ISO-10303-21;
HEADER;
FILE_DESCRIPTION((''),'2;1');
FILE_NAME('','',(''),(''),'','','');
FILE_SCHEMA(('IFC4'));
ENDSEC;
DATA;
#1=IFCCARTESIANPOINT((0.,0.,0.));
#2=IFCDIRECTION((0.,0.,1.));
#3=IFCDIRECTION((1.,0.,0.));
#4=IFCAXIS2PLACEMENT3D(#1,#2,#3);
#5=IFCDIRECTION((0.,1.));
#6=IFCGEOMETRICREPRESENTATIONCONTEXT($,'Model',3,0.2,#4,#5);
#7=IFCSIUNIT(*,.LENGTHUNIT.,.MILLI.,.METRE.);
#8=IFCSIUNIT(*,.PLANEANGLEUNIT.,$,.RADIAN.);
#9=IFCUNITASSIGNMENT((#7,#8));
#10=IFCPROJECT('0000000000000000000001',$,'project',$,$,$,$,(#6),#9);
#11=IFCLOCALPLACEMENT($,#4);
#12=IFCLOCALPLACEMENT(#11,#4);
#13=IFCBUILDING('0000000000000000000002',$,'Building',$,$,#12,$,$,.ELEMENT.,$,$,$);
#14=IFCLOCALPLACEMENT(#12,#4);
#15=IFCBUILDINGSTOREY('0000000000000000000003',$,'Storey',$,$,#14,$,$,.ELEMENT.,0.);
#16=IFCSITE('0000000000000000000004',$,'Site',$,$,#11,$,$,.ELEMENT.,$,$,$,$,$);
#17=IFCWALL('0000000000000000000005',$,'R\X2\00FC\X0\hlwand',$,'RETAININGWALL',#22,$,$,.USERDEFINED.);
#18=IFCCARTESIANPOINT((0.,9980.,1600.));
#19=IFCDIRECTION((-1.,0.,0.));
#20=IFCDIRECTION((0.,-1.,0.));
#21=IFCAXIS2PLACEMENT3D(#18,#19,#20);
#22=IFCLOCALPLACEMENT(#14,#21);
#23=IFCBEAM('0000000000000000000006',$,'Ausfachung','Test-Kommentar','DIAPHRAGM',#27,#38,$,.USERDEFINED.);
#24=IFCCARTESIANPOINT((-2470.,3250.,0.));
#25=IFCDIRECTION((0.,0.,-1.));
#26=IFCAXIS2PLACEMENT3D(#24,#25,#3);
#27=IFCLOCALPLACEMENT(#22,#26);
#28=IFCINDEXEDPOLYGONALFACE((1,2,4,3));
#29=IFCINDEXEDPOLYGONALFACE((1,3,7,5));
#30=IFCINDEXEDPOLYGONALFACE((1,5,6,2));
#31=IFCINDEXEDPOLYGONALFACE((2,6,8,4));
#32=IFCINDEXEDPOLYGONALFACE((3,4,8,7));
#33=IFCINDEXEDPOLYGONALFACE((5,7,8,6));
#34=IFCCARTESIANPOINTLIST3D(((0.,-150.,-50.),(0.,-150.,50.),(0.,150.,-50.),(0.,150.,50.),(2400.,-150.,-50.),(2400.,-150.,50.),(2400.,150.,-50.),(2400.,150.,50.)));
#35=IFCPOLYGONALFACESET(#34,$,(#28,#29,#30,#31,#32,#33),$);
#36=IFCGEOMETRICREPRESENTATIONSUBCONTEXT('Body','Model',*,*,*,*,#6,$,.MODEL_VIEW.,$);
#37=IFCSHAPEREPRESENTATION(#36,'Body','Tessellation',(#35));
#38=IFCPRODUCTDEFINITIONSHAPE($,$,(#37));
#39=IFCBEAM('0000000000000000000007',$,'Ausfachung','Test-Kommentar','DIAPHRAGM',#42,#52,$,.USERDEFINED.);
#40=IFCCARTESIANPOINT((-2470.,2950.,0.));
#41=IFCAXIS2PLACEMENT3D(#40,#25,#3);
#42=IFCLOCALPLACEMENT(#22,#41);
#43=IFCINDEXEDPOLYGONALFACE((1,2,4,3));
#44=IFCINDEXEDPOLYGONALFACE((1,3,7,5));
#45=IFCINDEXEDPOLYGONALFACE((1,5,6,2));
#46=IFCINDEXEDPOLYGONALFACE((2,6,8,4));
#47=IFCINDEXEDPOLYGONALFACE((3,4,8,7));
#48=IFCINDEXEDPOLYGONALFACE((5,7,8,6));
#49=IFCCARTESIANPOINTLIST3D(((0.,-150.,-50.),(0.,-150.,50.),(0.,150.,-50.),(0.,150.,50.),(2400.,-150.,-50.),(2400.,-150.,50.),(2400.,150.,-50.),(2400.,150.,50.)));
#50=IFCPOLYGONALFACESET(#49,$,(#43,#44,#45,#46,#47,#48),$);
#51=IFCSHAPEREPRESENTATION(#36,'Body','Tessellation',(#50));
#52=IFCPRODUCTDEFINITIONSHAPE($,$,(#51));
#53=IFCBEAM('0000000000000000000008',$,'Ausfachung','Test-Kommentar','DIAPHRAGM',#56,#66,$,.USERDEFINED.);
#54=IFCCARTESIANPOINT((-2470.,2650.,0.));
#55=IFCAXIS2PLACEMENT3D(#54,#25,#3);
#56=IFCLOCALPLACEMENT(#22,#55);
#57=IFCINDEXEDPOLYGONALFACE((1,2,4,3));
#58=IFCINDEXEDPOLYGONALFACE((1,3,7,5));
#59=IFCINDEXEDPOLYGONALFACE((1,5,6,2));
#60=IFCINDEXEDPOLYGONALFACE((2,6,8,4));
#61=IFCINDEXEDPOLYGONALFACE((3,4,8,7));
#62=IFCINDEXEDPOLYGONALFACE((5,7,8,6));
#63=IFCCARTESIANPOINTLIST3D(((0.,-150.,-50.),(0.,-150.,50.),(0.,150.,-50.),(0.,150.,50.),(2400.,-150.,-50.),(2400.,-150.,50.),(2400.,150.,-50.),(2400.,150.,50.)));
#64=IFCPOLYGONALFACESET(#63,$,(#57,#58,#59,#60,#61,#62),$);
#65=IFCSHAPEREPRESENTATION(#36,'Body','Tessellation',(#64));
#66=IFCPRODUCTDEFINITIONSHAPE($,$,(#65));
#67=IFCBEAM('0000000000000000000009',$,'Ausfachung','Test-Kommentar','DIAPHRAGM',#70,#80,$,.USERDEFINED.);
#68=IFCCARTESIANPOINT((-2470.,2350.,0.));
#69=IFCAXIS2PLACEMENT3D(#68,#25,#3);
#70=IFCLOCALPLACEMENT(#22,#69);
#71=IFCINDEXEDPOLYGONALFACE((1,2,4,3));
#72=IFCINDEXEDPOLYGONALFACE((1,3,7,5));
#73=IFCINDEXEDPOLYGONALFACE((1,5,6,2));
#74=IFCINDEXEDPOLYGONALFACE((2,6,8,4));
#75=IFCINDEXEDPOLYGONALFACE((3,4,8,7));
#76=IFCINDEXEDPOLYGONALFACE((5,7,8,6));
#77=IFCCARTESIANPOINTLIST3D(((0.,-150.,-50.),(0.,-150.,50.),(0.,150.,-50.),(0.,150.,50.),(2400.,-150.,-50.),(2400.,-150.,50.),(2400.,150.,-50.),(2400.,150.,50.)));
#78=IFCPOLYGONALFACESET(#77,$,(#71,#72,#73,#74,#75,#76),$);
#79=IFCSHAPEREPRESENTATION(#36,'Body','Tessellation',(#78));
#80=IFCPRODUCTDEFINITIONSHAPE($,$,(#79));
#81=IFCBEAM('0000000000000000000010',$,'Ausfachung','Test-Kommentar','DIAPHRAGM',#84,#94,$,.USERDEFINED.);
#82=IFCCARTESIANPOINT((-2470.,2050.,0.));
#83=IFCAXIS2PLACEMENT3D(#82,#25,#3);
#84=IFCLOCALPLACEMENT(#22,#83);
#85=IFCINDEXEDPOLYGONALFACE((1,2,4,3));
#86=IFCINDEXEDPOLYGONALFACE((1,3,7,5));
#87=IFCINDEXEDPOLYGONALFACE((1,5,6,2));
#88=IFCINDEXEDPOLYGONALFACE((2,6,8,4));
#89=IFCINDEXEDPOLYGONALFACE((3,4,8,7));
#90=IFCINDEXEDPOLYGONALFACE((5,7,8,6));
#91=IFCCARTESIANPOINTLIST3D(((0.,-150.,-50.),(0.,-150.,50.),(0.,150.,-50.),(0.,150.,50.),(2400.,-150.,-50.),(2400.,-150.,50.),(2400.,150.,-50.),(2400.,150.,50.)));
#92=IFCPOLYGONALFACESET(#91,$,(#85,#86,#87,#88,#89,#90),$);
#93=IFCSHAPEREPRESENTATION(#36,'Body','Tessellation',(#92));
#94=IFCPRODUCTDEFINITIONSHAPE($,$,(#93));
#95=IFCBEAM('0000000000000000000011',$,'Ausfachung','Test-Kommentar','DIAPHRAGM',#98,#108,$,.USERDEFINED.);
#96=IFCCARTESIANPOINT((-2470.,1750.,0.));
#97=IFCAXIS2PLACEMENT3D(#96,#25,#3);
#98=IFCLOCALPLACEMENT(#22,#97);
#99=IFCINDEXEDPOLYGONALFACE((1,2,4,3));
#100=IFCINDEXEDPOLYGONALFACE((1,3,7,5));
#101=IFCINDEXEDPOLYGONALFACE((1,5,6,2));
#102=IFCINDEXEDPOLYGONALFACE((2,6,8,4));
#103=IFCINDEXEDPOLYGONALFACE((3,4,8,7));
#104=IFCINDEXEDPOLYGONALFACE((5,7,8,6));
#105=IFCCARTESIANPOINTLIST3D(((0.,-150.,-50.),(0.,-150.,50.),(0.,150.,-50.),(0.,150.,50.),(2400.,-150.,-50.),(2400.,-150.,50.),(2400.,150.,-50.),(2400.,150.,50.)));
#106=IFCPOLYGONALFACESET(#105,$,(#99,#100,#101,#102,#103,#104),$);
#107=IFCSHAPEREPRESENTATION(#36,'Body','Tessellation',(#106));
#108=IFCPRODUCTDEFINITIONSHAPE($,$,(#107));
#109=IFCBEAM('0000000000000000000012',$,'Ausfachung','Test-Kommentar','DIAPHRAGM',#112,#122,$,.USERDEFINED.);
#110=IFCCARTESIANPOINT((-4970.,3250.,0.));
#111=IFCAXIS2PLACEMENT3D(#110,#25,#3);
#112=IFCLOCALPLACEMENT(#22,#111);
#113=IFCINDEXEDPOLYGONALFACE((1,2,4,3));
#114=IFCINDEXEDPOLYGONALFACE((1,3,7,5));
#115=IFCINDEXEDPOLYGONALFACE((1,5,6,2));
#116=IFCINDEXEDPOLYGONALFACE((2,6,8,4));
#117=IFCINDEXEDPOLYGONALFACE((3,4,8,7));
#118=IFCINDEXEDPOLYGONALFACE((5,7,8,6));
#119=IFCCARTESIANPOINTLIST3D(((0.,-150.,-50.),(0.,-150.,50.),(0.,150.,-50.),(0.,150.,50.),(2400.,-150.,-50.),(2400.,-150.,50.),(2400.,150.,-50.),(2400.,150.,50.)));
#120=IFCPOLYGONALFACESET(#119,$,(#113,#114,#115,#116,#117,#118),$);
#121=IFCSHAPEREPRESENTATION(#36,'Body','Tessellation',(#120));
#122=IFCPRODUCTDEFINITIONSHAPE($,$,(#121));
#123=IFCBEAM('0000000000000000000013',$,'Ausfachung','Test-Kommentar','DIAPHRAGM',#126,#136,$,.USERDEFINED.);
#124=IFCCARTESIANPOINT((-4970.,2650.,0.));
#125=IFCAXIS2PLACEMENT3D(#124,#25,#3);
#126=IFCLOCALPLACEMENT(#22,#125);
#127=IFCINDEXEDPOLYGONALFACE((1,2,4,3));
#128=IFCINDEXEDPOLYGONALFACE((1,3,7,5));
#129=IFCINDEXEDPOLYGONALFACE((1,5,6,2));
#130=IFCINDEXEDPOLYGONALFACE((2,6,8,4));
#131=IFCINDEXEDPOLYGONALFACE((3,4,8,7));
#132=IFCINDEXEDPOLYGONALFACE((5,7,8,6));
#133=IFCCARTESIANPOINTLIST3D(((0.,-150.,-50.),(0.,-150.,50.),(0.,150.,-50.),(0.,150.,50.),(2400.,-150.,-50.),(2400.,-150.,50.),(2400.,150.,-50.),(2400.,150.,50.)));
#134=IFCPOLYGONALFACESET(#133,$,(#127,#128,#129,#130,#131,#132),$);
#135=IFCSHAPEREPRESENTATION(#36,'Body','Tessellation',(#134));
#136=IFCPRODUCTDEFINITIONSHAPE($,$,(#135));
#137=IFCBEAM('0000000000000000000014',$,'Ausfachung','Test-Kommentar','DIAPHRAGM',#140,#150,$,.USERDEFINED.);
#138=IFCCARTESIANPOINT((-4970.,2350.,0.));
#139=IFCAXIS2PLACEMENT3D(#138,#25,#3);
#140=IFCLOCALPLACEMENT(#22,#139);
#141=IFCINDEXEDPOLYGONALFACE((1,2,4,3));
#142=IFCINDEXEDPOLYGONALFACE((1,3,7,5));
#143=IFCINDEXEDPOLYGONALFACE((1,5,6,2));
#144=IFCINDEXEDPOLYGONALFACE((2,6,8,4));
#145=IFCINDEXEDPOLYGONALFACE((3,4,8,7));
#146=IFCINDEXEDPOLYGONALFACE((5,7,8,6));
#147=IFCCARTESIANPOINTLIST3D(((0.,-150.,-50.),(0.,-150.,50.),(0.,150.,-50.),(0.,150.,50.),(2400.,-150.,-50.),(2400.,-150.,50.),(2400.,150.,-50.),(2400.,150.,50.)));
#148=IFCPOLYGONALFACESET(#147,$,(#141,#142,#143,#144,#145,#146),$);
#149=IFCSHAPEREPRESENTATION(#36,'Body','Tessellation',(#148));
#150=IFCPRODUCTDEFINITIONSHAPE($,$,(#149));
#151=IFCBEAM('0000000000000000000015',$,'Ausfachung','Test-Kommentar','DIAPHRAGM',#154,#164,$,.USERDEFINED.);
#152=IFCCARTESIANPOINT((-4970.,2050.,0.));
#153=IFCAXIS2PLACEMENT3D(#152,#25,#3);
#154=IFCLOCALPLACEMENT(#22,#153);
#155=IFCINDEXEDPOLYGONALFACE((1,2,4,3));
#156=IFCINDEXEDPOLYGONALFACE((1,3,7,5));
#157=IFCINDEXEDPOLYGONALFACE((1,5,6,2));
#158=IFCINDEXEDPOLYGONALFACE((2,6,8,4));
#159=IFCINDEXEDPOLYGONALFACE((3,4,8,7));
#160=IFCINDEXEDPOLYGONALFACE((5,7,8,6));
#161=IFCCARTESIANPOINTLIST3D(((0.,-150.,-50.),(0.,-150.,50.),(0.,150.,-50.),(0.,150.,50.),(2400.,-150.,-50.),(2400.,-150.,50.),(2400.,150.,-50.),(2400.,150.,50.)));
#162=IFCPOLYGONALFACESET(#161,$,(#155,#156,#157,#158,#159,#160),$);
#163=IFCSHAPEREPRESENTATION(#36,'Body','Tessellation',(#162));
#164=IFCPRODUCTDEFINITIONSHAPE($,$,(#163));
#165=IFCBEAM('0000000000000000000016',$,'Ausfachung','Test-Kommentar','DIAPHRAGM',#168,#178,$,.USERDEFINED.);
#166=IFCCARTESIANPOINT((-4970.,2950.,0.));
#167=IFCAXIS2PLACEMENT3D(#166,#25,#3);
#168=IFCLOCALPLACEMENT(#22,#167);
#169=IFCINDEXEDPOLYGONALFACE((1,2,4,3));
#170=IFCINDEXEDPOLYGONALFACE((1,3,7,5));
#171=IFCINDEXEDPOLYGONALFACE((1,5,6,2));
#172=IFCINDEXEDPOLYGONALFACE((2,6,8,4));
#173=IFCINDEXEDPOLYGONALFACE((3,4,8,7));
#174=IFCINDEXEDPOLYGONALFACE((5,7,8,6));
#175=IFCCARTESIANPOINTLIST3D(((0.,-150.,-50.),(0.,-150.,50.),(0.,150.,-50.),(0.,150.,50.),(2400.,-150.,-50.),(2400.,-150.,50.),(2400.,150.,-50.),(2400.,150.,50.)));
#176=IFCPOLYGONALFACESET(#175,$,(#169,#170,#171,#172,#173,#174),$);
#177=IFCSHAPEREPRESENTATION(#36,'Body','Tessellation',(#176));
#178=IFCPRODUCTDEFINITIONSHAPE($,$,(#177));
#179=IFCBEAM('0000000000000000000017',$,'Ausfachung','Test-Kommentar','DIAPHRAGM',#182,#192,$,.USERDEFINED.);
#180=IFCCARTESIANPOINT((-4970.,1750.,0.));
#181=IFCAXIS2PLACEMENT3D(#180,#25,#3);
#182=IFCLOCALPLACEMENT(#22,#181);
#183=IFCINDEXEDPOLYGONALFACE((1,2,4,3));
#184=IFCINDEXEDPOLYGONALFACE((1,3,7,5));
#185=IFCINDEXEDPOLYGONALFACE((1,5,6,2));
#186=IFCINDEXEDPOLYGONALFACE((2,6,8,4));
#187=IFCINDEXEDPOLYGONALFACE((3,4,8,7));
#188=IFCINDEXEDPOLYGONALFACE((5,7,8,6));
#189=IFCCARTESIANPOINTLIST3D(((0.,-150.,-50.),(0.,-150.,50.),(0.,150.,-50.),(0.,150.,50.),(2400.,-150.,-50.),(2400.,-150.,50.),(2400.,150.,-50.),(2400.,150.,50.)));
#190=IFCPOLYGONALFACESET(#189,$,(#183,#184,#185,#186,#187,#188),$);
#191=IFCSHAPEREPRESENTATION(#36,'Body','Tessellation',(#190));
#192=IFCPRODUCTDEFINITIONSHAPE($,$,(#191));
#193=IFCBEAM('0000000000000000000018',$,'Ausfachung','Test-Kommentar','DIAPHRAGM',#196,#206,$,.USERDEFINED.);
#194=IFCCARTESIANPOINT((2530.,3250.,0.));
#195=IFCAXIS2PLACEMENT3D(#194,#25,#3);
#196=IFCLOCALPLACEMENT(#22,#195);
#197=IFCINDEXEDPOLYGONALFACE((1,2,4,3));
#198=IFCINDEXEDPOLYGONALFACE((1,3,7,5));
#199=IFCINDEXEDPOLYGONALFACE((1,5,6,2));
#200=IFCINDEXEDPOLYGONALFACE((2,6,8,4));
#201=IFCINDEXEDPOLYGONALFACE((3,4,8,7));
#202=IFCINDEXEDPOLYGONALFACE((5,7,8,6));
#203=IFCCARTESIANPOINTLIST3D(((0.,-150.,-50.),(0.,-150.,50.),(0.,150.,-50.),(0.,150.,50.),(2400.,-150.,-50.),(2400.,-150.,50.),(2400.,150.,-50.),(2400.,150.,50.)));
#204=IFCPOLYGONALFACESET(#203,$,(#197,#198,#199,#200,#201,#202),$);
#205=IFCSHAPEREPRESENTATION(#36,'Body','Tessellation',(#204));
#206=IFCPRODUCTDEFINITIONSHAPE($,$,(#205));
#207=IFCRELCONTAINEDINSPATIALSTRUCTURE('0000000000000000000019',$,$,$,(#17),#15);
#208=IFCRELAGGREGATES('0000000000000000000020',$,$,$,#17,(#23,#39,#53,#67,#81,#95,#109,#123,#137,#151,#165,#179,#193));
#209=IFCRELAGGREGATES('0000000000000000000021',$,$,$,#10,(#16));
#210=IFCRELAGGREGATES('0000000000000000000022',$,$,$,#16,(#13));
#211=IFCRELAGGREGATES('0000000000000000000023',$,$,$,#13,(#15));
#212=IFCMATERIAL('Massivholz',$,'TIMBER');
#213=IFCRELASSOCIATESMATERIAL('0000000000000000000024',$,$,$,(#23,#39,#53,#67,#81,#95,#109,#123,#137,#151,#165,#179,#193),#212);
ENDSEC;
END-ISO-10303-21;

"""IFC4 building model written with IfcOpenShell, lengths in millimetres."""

from ifc_helpers import new_model, si_unit, direction, frame, origin_with_axes, place, context, subcontext, project, spatial, line, indexed_curve, outline, extrude, material, element, aggregate, save


model = new_model("IFC4")

# Units and contexts
model_context = context("Model", 3, precision=0.2, world=origin_with_axes(), true_north=direction((0.0, 1.0)))
body_context = subcontext(model_context, "Body", "Model", "MODEL_VIEW")
ifc_project = project(units=[si_unit("LENGTHUNIT", "METRE", prefix="MILLI"), si_unit("PLANEANGLEUNIT", "RADIAN")], contexts=[model_context])

# Site, building, storey
site_placement = place(None, origin_with_axes())
site = spatial("IfcSite", under=ifc_project, at=site_placement, Name="Site", CompositionType="ELEMENT")
building_placement = place(site_placement, origin_with_axes())
building = spatial("IfcBuilding", under=site, at=building_placement, Name="Building", CompositionType="ELEMENT")
storey_placement = place(building_placement, origin_with_axes())
storey = spatial("IfcBuildingStorey", under=building, at=storey_placement, Name="Storey", CompositionType="ELEMENT", Elevation=0.0)

# Wall, beams
wall_placement = place(storey_placement, frame((0.0, 9980.0, 1600.0), z_axis=(-1.0, 0.0, 0.0), x_axis=(0.0, -1.0, 0.0)))
wall = element("IfcWall", 1, at=wall_placement, inside=storey, Name="Rühlwand", ObjectType="RETAININGWALL", PredefinedType="USERDEFINED")
ifc_material_1 = material(Name="Massivholz", Category="TIMBER")
beam_1_placement = place(wall_placement, frame((-2470.0, 3250.0, 0.0), z_axis=(0.0, 0.0, -1.0), x_axis=(1.0, 0.0, 0.0)))
beam_1 = element("IfcBeam", 2, at=beam_1_placement, material=ifc_material_1, Name="Ausfachung", Description="Test-Kommentar", ObjectType="DIAPHRAGM", PredefinedType="USERDEFINED", context=body_context, shape_type="SolidModel", body=[
    extrude(outline(indexed_curve([(-50.0, -150.0), (50.0, -150.0), (50.0, 150.0), (-50.0, 150.0)], segments=[line(1, 2, 3, 4, 1)])), frame((0.0, 0.0, 0.0), z_axis=(-1.0, 0.0, 0.0), x_axis=(0.0, 0.0, 1.0)), (0.0, 0.0, -1.0), 2400.0),
])
beam_2_placement = place(wall_placement, frame((-2470.0, 2950.0, 0.0), z_axis=(0.0, 0.0, -1.0), x_axis=(1.0, 0.0, 0.0)))
beam_2 = element("IfcBeam", 3, at=beam_2_placement, material=ifc_material_1, Name="Ausfachung", Description="Test-Kommentar", ObjectType="DIAPHRAGM", PredefinedType="USERDEFINED", context=body_context, shape_type="SolidModel", body=[
    extrude(outline(indexed_curve([(-50.0, -150.0), (50.0, -150.0), (50.0, 150.0), (-50.0, 150.0)], segments=[line(1, 2, 3, 4, 1)])), frame((0.0, 0.0, 0.0), z_axis=(-1.0, 0.0, 0.0), x_axis=(0.0, 0.0, 1.0)), (0.0, 0.0, -1.0), 2400.0),
])
beam_3_placement = place(wall_placement, frame((-2470.0, 2650.0, 0.0), z_axis=(0.0, 0.0, -1.0), x_axis=(1.0, 0.0, 0.0)))
beam_3 = element("IfcBeam", 4, at=beam_3_placement, material=ifc_material_1, Name="Ausfachung", Description="Test-Kommentar", ObjectType="DIAPHRAGM", PredefinedType="USERDEFINED", context=body_context, shape_type="SolidModel", body=[
    extrude(outline(indexed_curve([(-50.0, -150.0), (50.0, -150.0), (50.0, 150.0), (-50.0, 150.0)], segments=[line(1, 2, 3, 4, 1)])), frame((0.0, 0.0, 0.0), z_axis=(-1.0, 0.0, 0.0), x_axis=(0.0, 0.0, 1.0)), (0.0, 0.0, -1.0), 2400.0),
])
beam_4_placement = place(wall_placement, frame((-2470.0, 2350.0, 0.0), z_axis=(0.0, 0.0, -1.0), x_axis=(1.0, 0.0, 0.0)))
beam_4 = element("IfcBeam", 5, at=beam_4_placement, material=ifc_material_1, Name="Ausfachung", Description="Test-Kommentar", ObjectType="DIAPHRAGM", PredefinedType="USERDEFINED", context=body_context, shape_type="SolidModel", body=[
    extrude(outline(indexed_curve([(-50.0, -150.0), (50.0, -150.0), (50.0, 150.0), (-50.0, 150.0)], segments=[line(1, 2, 3, 4, 1)])), frame((0.0, 0.0, 0.0), z_axis=(-1.0, 0.0, 0.0), x_axis=(0.0, 0.0, 1.0)), (0.0, 0.0, -1.0), 2400.0),
])
beam_5_placement = place(wall_placement, frame((-2470.0, 2050.0, 0.0), z_axis=(0.0, 0.0, -1.0), x_axis=(1.0, 0.0, 0.0)))
beam_5 = element("IfcBeam", 6, at=beam_5_placement, material=ifc_material_1, Name="Ausfachung", Description="Test-Kommentar", ObjectType="DIAPHRAGM", PredefinedType="USERDEFINED", context=body_context, shape_type="SolidModel", body=[
    extrude(outline(indexed_curve([(-50.0, -150.0), (50.0, -150.0), (50.0, 150.0), (-50.0, 150.0)], segments=[line(1, 2, 3, 4, 1)])), frame((0.0, 0.0, 0.0), z_axis=(-1.0, 0.0, 0.0), x_axis=(0.0, 0.0, 1.0)), (0.0, 0.0, -1.0), 2400.0),
])
beam_6_placement = place(wall_placement, frame((-2470.0, 1750.0, 0.0), z_axis=(0.0, 0.0, -1.0), x_axis=(1.0, 0.0, 0.0)))
beam_6 = element("IfcBeam", 7, at=beam_6_placement, material=ifc_material_1, Name="Ausfachung", Description="Test-Kommentar", ObjectType="DIAPHRAGM", PredefinedType="USERDEFINED", context=body_context, shape_type="SolidModel", body=[
    extrude(outline(indexed_curve([(-50.0, -150.0), (50.0, -150.0), (50.0, 150.0), (-50.0, 150.0)], segments=[line(1, 2, 3, 4, 1)])), frame((0.0, 0.0, 0.0), z_axis=(-1.0, 0.0, 0.0), x_axis=(0.0, 0.0, 1.0)), (0.0, 0.0, -1.0), 2400.0),
])
beam_7_placement = place(wall_placement, frame((-4970.0, 3250.0, 0.0), z_axis=(0.0, 0.0, -1.0), x_axis=(1.0, 0.0, 0.0)))
beam_7 = element("IfcBeam", 8, at=beam_7_placement, material=ifc_material_1, Name="Ausfachung", Description="Test-Kommentar", ObjectType="DIAPHRAGM", PredefinedType="USERDEFINED", context=body_context, shape_type="SolidModel", body=[
    extrude(outline(indexed_curve([(-50.0, -150.0), (50.0, -150.0), (50.0, 150.0), (-50.0, 150.0)], segments=[line(1, 2, 3, 4, 1)])), frame((0.0, 0.0, 0.0), z_axis=(-1.0, 0.0, 0.0), x_axis=(0.0, 0.0, 1.0)), (0.0, 0.0, -1.0), 2400.0),
])
beam_8_placement = place(wall_placement, frame((-4970.0, 2650.0, 0.0), z_axis=(0.0, 0.0, -1.0), x_axis=(1.0, 0.0, 0.0)))
beam_8 = element("IfcBeam", 9, at=beam_8_placement, material=ifc_material_1, Name="Ausfachung", Description="Test-Kommentar", ObjectType="DIAPHRAGM", PredefinedType="USERDEFINED", context=body_context, shape_type="SolidModel", body=[
    extrude(outline(indexed_curve([(-50.0, -150.0), (50.0, -150.0), (50.0, 150.0), (-50.0, 150.0)], segments=[line(1, 2, 3, 4, 1)])), frame((0.0, 0.0, 0.0), z_axis=(-1.0, 0.0, 0.0), x_axis=(0.0, 0.0, 1.0)), (0.0, 0.0, -1.0), 2400.0),
])
beam_9_placement = place(wall_placement, frame((-4970.0, 2350.0, 0.0), z_axis=(0.0, 0.0, -1.0), x_axis=(1.0, 0.0, 0.0)))
beam_9 = element("IfcBeam", 10, at=beam_9_placement, material=ifc_material_1, Name="Ausfachung", Description="Test-Kommentar", ObjectType="DIAPHRAGM", PredefinedType="USERDEFINED", context=body_context, shape_type="SolidModel", body=[
    extrude(outline(indexed_curve([(-50.0, -150.0), (50.0, -150.0), (50.0, 150.0), (-50.0, 150.0)], segments=[line(1, 2, 3, 4, 1)])), frame((0.0, 0.0, 0.0), z_axis=(-1.0, 0.0, 0.0), x_axis=(0.0, 0.0, 1.0)), (0.0, 0.0, -1.0), 2400.0),
])
beam_10_placement = place(wall_placement, frame((-4970.0, 2050.0, 0.0), z_axis=(0.0, 0.0, -1.0), x_axis=(1.0, 0.0, 0.0)))
beam_10 = element("IfcBeam", 11, at=beam_10_placement, material=ifc_material_1, Name="Ausfachung", Description="Test-Kommentar", ObjectType="DIAPHRAGM", PredefinedType="USERDEFINED", context=body_context, shape_type="SolidModel", body=[
    extrude(outline(indexed_curve([(-50.0, -150.0), (50.0, -150.0), (50.0, 150.0), (-50.0, 150.0)], segments=[line(1, 2, 3, 4, 1)])), frame((0.0, 0.0, 0.0), z_axis=(-1.0, 0.0, 0.0), x_axis=(0.0, 0.0, 1.0)), (0.0, 0.0, -1.0), 2400.0),
])
beam_11_placement = place(wall_placement, frame((-4970.0, 2950.0, 0.0), z_axis=(0.0, 0.0, -1.0), x_axis=(1.0, 0.0, 0.0)))
beam_11 = element("IfcBeam", 12, at=beam_11_placement, material=ifc_material_1, Name="Ausfachung", Description="Test-Kommentar", ObjectType="DIAPHRAGM", PredefinedType="USERDEFINED", context=body_context, shape_type="SolidModel", body=[
    extrude(outline(indexed_curve([(-50.0, -150.0), (50.0, -150.0), (50.0, 150.0), (-50.0, 150.0)], segments=[line(1, 2, 3, 4, 1)])), frame((0.0, 0.0, 0.0), z_axis=(-1.0, 0.0, 0.0), x_axis=(0.0, 0.0, 1.0)), (0.0, 0.0, -1.0), 2400.0),
])
beam_12_placement = place(wall_placement, frame((-4970.0, 1750.0, 0.0), z_axis=(0.0, 0.0, -1.0), x_axis=(1.0, 0.0, 0.0)))
beam_12 = element("IfcBeam", 13, at=beam_12_placement, material=ifc_material_1, Name="Ausfachung", Description="Test-Kommentar", ObjectType="DIAPHRAGM", PredefinedType="USERDEFINED", context=body_context, shape_type="SolidModel", body=[
    extrude(outline(indexed_curve([(-50.0, -150.0), (50.0, -150.0), (50.0, 150.0), (-50.0, 150.0)], segments=[line(1, 2, 3, 4, 1)])), frame((0.0, 0.0, 0.0), z_axis=(-1.0, 0.0, 0.0), x_axis=(0.0, 0.0, 1.0)), (0.0, 0.0, -1.0), 2400.0),
])
beam_13_placement = place(wall_placement, frame((2530.0, 3250.0, 0.0), z_axis=(0.0, 0.0, -1.0), x_axis=(1.0, 0.0, 0.0)))
beam_13 = element("IfcBeam", 14, at=beam_13_placement, material=ifc_material_1, Name="Ausfachung", Description="Test-Kommentar", ObjectType="DIAPHRAGM", PredefinedType="USERDEFINED", context=body_context, shape_type="SolidModel", body=[
    extrude(outline(indexed_curve([(-50.0, -150.0), (50.0, -150.0), (50.0, 150.0), (-50.0, 150.0)], segments=[line(1, 2, 3, 4, 1)])), frame((0.0, 0.0, 0.0), z_axis=(-1.0, 0.0, 0.0), x_axis=(0.0, 0.0, 1.0)), (0.0, 0.0, -1.0), 2400.0),
])
aggregate(wall, [beam_1, beam_2, beam_3, beam_4, beam_5, beam_6, beam_7, beam_8, beam_9, beam_10, beam_11, beam_12, beam_13])

save(model, "model.ifc")
